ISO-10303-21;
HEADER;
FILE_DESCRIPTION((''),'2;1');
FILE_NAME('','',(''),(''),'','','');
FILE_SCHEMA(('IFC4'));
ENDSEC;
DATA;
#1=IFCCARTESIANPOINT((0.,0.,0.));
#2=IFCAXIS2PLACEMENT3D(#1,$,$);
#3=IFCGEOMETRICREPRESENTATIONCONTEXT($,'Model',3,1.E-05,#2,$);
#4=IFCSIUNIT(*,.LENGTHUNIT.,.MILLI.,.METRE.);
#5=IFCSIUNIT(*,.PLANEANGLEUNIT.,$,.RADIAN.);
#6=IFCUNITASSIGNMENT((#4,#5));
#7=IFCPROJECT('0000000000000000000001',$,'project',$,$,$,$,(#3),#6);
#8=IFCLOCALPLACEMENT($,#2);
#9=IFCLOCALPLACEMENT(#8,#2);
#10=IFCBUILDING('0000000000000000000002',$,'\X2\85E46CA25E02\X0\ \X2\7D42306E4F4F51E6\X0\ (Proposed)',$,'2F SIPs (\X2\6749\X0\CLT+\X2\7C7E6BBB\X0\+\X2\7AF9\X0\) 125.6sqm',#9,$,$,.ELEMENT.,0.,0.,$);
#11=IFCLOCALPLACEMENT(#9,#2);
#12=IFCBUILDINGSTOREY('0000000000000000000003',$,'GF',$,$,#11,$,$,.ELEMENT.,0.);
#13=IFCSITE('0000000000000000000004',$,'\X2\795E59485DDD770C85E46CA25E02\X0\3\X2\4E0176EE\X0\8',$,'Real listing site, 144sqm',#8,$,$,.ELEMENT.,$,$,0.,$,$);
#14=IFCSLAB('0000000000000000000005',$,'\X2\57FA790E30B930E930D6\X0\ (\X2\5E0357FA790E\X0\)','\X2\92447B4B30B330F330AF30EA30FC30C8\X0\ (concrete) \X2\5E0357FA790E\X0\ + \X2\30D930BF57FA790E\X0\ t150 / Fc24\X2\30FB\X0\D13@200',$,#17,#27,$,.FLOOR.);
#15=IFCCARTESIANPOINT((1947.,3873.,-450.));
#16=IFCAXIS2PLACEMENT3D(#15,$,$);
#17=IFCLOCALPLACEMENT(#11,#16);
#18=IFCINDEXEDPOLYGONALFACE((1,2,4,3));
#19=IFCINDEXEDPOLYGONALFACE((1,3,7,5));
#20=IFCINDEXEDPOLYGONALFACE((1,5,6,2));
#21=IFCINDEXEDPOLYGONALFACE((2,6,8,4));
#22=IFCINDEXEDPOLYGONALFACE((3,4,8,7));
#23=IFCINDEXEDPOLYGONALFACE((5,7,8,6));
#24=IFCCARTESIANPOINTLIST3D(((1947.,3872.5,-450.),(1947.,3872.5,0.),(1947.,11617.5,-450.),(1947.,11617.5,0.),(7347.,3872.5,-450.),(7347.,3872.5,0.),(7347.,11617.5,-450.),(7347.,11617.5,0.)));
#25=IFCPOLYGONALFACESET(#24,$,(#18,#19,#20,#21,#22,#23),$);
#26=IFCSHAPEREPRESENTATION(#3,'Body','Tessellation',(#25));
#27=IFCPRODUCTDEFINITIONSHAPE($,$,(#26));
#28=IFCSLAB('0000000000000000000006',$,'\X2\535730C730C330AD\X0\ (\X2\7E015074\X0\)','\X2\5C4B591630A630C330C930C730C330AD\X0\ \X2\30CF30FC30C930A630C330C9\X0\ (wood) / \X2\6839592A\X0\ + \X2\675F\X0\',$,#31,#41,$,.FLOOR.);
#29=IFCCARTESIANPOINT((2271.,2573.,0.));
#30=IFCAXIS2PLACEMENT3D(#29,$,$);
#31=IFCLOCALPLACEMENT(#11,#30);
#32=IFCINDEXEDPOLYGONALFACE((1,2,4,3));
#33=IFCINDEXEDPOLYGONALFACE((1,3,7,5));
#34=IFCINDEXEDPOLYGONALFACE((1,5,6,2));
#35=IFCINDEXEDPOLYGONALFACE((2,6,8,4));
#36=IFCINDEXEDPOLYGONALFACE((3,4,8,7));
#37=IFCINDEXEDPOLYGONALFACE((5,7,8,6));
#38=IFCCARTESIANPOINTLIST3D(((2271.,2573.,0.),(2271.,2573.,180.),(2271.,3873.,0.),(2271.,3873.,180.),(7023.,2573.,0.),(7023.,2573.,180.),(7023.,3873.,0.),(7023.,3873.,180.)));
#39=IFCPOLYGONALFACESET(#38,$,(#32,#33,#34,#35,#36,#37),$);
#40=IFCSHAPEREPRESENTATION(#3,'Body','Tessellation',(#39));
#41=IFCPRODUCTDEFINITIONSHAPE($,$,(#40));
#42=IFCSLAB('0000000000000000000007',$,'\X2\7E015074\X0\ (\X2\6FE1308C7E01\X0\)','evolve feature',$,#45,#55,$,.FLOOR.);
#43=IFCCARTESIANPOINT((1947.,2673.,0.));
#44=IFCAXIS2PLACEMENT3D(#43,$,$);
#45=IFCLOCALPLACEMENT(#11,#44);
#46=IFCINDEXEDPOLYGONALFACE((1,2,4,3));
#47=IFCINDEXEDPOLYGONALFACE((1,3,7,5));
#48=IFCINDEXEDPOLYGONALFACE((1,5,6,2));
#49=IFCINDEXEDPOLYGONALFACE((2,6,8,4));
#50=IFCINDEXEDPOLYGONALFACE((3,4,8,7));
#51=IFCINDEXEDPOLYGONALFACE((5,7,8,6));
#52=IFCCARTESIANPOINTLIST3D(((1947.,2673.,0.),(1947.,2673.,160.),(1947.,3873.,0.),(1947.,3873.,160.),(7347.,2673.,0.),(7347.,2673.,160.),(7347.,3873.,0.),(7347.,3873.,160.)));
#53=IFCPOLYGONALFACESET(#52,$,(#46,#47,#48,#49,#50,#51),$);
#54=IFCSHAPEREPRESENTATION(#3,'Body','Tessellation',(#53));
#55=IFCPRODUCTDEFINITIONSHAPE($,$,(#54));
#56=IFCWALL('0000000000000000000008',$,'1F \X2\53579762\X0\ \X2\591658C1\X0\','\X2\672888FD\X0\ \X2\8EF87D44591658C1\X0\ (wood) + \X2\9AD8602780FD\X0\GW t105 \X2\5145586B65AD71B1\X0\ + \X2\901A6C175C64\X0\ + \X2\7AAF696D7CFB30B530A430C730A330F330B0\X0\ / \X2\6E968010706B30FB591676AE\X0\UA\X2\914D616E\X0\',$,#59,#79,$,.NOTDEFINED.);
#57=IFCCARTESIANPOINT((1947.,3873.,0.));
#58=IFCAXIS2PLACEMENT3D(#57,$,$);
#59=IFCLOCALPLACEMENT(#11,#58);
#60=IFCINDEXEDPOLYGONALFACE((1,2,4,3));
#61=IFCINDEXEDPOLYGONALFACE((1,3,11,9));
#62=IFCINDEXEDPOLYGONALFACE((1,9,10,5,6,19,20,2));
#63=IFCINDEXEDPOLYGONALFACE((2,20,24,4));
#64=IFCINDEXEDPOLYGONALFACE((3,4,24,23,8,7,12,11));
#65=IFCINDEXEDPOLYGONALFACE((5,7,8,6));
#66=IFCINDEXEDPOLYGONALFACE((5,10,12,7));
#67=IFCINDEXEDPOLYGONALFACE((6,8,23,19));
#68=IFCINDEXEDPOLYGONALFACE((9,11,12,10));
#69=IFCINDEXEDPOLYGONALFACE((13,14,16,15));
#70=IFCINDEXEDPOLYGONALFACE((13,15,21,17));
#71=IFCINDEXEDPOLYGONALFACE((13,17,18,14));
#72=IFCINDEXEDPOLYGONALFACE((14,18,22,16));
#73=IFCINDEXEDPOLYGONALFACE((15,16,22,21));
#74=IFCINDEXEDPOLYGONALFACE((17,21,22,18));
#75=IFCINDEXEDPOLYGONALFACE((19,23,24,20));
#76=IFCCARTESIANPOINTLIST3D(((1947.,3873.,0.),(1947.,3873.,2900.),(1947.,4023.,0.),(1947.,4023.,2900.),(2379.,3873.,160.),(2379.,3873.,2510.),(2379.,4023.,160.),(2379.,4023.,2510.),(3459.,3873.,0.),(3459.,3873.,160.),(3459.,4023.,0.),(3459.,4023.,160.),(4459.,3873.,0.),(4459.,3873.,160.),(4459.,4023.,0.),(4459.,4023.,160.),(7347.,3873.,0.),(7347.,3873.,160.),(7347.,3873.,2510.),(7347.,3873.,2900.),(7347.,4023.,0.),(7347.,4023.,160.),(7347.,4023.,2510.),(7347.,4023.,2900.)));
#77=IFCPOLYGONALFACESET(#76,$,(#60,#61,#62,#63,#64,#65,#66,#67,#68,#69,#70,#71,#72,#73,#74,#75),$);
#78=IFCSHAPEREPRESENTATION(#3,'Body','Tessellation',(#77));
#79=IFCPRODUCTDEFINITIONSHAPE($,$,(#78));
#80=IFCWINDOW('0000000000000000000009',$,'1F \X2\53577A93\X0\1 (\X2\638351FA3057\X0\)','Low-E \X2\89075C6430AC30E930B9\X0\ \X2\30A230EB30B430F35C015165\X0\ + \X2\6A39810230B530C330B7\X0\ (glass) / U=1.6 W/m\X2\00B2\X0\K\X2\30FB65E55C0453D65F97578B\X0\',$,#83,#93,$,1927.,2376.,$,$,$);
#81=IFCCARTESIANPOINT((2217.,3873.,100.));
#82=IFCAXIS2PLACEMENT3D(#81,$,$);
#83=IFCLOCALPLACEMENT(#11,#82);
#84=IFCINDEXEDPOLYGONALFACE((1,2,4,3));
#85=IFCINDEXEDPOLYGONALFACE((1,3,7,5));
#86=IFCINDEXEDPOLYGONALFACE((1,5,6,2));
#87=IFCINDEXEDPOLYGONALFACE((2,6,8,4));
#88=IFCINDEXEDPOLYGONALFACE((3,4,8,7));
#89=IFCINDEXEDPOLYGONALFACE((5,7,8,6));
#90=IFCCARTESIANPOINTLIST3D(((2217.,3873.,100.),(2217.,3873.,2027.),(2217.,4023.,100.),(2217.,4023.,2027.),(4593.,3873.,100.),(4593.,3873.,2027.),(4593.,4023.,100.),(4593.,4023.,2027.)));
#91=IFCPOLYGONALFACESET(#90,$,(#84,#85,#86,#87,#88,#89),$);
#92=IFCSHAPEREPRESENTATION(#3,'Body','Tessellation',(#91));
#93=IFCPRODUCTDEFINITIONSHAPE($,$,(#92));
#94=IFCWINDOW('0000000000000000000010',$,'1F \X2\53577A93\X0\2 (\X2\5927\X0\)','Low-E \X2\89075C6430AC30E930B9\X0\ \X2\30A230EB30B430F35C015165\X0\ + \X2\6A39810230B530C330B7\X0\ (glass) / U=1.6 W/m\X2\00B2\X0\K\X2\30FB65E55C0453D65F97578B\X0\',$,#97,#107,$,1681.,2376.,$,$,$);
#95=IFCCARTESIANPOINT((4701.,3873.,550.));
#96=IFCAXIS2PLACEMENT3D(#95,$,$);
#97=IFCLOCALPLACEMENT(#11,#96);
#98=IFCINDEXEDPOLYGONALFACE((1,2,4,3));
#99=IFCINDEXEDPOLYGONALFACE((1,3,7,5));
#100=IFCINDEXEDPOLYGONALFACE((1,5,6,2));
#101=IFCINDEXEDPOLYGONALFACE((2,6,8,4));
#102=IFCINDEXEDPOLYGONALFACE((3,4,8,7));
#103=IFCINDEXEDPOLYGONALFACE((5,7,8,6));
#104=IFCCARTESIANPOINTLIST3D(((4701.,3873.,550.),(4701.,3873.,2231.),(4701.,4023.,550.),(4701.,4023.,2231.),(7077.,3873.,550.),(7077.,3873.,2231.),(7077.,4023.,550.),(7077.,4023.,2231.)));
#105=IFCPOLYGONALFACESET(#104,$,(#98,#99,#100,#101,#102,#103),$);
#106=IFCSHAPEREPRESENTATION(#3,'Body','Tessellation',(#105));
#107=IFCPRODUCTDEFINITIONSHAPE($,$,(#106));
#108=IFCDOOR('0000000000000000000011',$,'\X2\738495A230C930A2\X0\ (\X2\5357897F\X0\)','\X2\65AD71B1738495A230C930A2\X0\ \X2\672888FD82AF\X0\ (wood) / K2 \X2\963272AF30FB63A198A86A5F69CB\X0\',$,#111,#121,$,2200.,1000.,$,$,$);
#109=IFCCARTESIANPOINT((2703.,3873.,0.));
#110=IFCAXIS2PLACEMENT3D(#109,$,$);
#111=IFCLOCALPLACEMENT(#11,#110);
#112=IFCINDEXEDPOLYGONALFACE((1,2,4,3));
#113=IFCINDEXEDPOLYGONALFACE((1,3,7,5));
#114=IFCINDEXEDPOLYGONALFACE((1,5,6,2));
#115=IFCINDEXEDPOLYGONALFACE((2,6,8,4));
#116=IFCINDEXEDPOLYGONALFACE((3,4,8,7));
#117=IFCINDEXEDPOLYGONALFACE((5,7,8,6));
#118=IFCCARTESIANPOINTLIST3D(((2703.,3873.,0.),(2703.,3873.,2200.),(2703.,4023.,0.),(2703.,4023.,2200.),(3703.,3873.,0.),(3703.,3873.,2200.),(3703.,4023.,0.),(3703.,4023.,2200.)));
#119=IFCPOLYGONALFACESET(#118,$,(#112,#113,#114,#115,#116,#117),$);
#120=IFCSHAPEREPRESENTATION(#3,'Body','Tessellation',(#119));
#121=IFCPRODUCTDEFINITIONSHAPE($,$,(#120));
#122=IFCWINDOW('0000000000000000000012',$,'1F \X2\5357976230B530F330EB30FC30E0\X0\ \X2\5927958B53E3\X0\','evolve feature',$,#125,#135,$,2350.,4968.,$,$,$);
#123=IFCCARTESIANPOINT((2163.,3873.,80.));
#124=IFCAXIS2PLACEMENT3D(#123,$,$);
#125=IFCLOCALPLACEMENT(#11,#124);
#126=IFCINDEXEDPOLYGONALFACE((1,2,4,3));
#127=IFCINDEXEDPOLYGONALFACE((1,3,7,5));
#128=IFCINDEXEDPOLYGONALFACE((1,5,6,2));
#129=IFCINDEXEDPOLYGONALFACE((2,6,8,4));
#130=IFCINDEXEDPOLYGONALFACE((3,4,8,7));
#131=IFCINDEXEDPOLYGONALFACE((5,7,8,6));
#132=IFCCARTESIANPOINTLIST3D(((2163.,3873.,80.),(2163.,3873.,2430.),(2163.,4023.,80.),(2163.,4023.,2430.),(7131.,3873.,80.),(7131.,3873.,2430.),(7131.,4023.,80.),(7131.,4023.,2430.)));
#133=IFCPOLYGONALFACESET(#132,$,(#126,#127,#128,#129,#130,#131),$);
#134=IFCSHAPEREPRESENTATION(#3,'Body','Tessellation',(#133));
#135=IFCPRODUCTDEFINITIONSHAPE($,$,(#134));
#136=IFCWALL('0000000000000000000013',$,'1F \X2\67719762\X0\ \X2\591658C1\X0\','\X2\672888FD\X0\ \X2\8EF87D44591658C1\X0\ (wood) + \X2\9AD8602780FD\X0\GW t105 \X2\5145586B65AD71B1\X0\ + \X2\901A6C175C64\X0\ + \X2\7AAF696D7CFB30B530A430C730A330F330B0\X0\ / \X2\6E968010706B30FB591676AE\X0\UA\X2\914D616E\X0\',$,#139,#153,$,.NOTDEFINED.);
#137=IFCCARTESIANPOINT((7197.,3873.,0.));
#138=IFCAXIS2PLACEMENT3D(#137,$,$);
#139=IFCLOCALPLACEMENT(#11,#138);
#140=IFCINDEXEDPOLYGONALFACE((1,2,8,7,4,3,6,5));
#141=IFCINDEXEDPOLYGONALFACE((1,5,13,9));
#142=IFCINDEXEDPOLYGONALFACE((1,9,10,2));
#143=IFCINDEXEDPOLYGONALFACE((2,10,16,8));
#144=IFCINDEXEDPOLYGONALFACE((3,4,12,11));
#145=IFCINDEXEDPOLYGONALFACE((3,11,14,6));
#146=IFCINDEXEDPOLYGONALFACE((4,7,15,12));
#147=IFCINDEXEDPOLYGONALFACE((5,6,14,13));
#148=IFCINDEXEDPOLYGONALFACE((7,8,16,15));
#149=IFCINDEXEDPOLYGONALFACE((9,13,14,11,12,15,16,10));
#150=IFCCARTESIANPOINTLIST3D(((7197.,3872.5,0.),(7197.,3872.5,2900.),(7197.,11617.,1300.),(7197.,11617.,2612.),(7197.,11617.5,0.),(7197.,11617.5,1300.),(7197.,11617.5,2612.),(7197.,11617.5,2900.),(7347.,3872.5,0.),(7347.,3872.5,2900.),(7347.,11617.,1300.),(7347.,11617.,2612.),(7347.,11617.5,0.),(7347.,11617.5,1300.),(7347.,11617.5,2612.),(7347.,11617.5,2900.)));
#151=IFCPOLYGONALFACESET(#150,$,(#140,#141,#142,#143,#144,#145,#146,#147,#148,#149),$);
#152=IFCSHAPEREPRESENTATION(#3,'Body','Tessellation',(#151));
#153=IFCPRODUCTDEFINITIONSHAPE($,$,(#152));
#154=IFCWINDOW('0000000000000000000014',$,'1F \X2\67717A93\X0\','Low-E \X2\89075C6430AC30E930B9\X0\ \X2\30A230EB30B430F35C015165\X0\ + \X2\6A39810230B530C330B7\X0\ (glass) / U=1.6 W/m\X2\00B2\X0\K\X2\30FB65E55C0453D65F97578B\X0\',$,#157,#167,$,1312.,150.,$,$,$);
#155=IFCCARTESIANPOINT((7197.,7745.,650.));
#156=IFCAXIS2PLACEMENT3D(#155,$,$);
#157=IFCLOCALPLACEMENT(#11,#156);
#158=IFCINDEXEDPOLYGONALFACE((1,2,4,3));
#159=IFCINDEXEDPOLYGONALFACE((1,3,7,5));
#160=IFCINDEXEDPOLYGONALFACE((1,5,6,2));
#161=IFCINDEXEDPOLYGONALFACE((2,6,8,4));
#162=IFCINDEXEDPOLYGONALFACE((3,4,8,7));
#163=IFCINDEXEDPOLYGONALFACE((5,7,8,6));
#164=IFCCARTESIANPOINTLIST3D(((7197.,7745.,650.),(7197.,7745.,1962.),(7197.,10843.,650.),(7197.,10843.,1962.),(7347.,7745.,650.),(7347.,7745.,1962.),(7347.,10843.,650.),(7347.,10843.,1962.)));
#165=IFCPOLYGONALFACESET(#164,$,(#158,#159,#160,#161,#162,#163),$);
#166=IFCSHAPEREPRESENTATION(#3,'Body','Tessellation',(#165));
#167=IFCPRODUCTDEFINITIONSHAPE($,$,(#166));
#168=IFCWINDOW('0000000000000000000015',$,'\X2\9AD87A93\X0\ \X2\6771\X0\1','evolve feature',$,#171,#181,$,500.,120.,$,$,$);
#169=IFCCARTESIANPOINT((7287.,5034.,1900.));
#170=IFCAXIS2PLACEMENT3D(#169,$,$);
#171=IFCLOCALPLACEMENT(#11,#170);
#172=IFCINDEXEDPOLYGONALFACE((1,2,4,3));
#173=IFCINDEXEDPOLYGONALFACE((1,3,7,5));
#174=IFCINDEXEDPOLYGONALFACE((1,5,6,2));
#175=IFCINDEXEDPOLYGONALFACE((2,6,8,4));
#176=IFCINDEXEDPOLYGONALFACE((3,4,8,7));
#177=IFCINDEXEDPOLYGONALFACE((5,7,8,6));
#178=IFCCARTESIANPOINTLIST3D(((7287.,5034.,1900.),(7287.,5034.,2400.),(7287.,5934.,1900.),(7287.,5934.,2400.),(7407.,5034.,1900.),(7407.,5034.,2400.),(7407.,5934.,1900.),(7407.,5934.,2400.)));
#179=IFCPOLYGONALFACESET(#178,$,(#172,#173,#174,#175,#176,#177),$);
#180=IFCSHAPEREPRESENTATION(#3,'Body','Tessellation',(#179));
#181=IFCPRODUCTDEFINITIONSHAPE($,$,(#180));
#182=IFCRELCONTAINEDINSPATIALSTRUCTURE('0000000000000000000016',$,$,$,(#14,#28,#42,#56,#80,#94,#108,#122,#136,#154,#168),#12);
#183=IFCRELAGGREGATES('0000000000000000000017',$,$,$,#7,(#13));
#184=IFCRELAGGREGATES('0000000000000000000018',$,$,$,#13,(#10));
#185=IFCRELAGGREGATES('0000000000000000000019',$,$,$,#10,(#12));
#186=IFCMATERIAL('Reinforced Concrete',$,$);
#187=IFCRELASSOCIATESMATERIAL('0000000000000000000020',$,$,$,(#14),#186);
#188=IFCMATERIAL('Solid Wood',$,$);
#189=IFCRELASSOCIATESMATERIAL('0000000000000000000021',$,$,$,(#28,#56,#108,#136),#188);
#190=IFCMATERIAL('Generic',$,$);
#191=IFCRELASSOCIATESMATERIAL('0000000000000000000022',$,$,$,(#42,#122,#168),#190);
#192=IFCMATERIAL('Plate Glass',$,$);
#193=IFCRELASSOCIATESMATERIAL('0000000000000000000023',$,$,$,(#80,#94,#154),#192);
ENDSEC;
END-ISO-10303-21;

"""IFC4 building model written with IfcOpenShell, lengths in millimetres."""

from ifc_helpers import new_model, si_unit, frame, frame_2d, origin, place, context, project, spatial, rectangle, extrude, material, element, fill, save


model = new_model("IFC4")

# Units and contexts
model_context = context("Model", 3, precision=1e-05, world=origin())
ifc_project = project(units=[si_unit("LENGTHUNIT", "METRE", prefix="MILLI"), si_unit("PLANEANGLEUNIT", "RADIAN")], contexts=[model_context])

# Site, building, storey
site_placement = place(None, origin())
site = spatial("IfcSite", under=ifc_project, at=site_placement, Name="神奈川県藤沢市3丁目8", ObjectType="Real listing site, 144sqm", CompositionType="ELEMENT", RefElevation=0.0)
building_placement = place(site_placement, origin())
building = spatial("IfcBuilding", under=site, at=building_placement, Name="藤沢市 終の住処 (Proposed)", ObjectType="2F SIPs (杉CLT+籾殻+竹) 125.6sqm", CompositionType="ELEMENT", ElevationOfRefHeight=0.0, ElevationOfTerrain=0.0)
storey_placement = place(building_placement, origin())
storey = spatial("IfcBuildingStorey", under=building, at=storey_placement, Name="GF", CompositionType="ELEMENT", Elevation=0.0)

# Slabs
ifc_material_1 = material(Name="Reinforced Concrete")
slab_1_placement = place(storey_placement, frame((1947.0, 3873.0, -450.0)))
element("IfcSlab", 1, at=slab_1_placement, inside=storey, material=ifc_material_1, Name="基礎スラブ (布基礎)", Description="鉄筋コンクリート (concrete) 布基礎 + ベタ基礎 t150 / Fc24・D13@200", PredefinedType="FLOOR", context=model_context, shape_type="SweptSolid", body=[
    extrude(rectangle(XDim=5400.0, YDim=7745.0, at=frame_2d((2700.0, 3872.0))), frame((1947.0, 3873.0, -450.0)), (0.0, 0.0, 1.0), 450.0),
])
ifc_material_2 = material(Name="Solid Wood")
slab_2_placement = place(storey_placement, frame((2271.0, 2573.0, 0.0)))
element("IfcSlab", 2, at=slab_2_placement, inside=storey, material=ifc_material_2, Name="南デッキ (縁側)", Description="屋外ウッドデッキ ハードウッド (wood) / 根太 + 束", PredefinedType="FLOOR", context=model_context, shape_type="SweptSolid", body=[
    extrude(rectangle(XDim=4752.0, YDim=1300.0, at=frame_2d((2376.0, 650.0))), frame((2271.0, 2573.0, 0.0)), (0.0, 0.0, 1.0), 180.0),
])
ifc_material_3 = material(Name="Generic")
slab_3_placement = place(storey_placement, frame((1947.0, 2673.0, 0.0)))
element("IfcSlab", 3, at=slab_3_placement, inside=storey, material=ifc_material_3, Name="縁側 (濡れ縁)", Description="evolve feature", PredefinedType="FLOOR", context=model_context, shape_type="SweptSolid", body=[
    extrude(rectangle(XDim=5400.0, YDim=1200.0, at=frame_2d((2700.0, 600.0))), frame((1947.0, 2673.0, 0.0)), (0.0, 0.0, 1.0), 160.0),
])

# Wall, openings, windows, door
wall_1_placement = place(storey_placement, frame((1947.0, 3873.0, 0.0)))
wall_1 = element("IfcWall", 4, at=wall_1_placement, inside=storey, material=ifc_material_2, Name="1F 南面 外壁", Description="木製 軸組外壁 (wood) + 高性能GW t105 充填断熱 + 通気層 + 窯業系サイディング / 準耐火・外皮UA配慮", PredefinedType="NOTDEFINED", context=model_context, shape_type="SweptSolid", body=[
    extrude(rectangle(XDim=5400.0, YDim=150.0, at=frame_2d((2700.0, 75.0))), frame((1947.0, 3873.0, 0.0)), (0.0, 0.0, 1.0), 2900.0),
])
opening_1_placement = place(storey_placement, frame((2217.0, 3873.0, 100.0)))
opening_1 = element("IfcOpeningElement", 5, at=opening_1_placement, cuts=wall_1, PredefinedType="NOTDEFINED", context=model_context, shape_type="SweptSolid", body=[
    extrude(rectangle(XDim=2376.0, YDim=150.0, at=frame_2d((1188.0, 75.0))), frame((2217.0, 3873.0, 100.0)), (0.0, 0.0, 1.0), 1927.0),
])
opening_2_placement = place(storey_placement, frame((4701.0, 3873.0, 550.0)))
opening_2 = element("IfcOpeningElement", 6, at=opening_2_placement, cuts=wall_1, PredefinedType="NOTDEFINED", context=model_context, shape_type="SweptSolid", body=[
    extrude(rectangle(XDim=2376.0, YDim=150.0, at=frame_2d((1188.0, 75.0))), frame((4701.0, 3873.0, 550.0)), (0.0, 0.0, 1.0), 1681.0),
])
opening_3_placement = place(storey_placement, frame((2703.0, 3873.0, 0.0)))
opening_3 = element("IfcOpeningElement", 7, at=opening_3_placement, cuts=wall_1, PredefinedType="NOTDEFINED", context=model_context, shape_type="SweptSolid", body=[
    extrude(rectangle(XDim=1000.0, YDim=150.0, at=frame_2d((500.0, 75.0))), frame((2703.0, 3873.0, 0.0)), (0.0, 0.0, 1.0), 2200.0),
])
opening_4_placement = place(storey_placement, frame((2163.0, 3873.0, 80.0)))
opening_4 = element("IfcOpeningElement", 8, at=opening_4_placement, cuts=wall_1, PredefinedType="NOTDEFINED", context=model_context, shape_type="SweptSolid", body=[
    extrude(rectangle(XDim=4968.0, YDim=150.0, at=frame_2d((2484.0, 75.0))), frame((2163.0, 3873.0, 80.0)), (0.0, 0.0, 1.0), 2350.0),
])
ifc_material_4 = material(Name="Plate Glass")
window_1_placement = place(storey_placement, frame((2217.0, 3873.0, 100.0)))
window_1 = element("IfcWindow", 9, at=window_1_placement, inside=storey, material=ifc_material_4, Name="1F 南窓1 (掃出し)", Description="Low-E 複層ガラス アルゴン封入 + 樹脂サッシ (glass) / U=1.6 W/m²K・日射取得型", OverallHeight=1927.0, OverallWidth=2376.0, context=model_context, shape_type="SweptSolid", body=[
    extrude(rectangle(XDim=2376.0, YDim=150.0, at=frame_2d((1188.0, 75.0))), frame((2217.0, 3873.0, 100.0)), (0.0, 0.0, 1.0), 1927.0),
])
fill(opening_1, window_1)
window_2_placement = place(storey_placement, frame((4701.0, 3873.0, 550.0)))
window_2 = element("IfcWindow", 10, at=window_2_placement, inside=storey, material=ifc_material_4, Name="1F 南窓2 (大)", Description="Low-E 複層ガラス アルゴン封入 + 樹脂サッシ (glass) / U=1.6 W/m²K・日射取得型", OverallHeight=1681.0, OverallWidth=2376.0, context=model_context, shape_type="SweptSolid", body=[
    extrude(rectangle(XDim=2376.0, YDim=150.0, at=frame_2d((1188.0, 75.0))), frame((4701.0, 3873.0, 550.0)), (0.0, 0.0, 1.0), 1681.0),
])
fill(opening_2, window_2)
door_placement = place(storey_placement, frame((2703.0, 3873.0, 0.0)))
door = element("IfcDoor", 11, at=door_placement, inside=storey, material=ifc_material_2, Name="玄関ドア (南西)", Description="断熱玄関ドア 木製芯 (wood) / K2 防犯・採風機構", OverallHeight=2200.0, OverallWidth=1000.0, context=model_context, shape_type="SweptSolid", body=[
    extrude(rectangle(XDim=1000.0, YDim=150.0, at=frame_2d((500.0, 75.0))), frame((2703.0, 3873.0, 0.0)), (0.0, 0.0, 1.0), 2200.0),
])
fill(opening_3, door)
window_3_placement = place(storey_placement, frame((2163.0, 3873.0, 80.0)))
window_3 = element("IfcWindow", 12, at=window_3_placement, inside=storey, material=ifc_material_3, Name="1F 南面サンルーム 大開口", Description="evolve feature", OverallHeight=2350.0, OverallWidth=4968.0, context=model_context, shape_type="SweptSolid", body=[
    extrude(rectangle(XDim=4968.0, YDim=150.0, at=frame_2d((2484.0, 75.0))), frame((2163.0, 3873.0, 80.0)), (0.0, 0.0, 1.0), 2350.0),
])
fill(opening_4, window_3)

# Wall, openings, windows
wall_2_placement = place(storey_placement, frame((7197.0, 3873.0, 0.0)))
wall_2 = element("IfcWall", 13, at=wall_2_placement, inside=storey, material=ifc_material_2, Name="1F 東面 外壁", Description="木製 軸組外壁 (wood) + 高性能GW t105 充填断熱 + 通気層 + 窯業系サイディング / 準耐火・外皮UA配慮", PredefinedType="NOTDEFINED", context=model_context, shape_type="SweptSolid", body=[
    extrude(rectangle(XDim=150.0, YDim=7745.0, at=frame_2d((75.0, 3872.0))), frame((7197.0, 3873.0, 0.0)), (0.0, 0.0, 1.0), 2900.0),
])
opening_5_placement = place(storey_placement, frame((7197.0, 7745.0, 650.0)))
opening_5 = element("IfcOpeningElement", 14, at=opening_5_placement, cuts=wall_2, PredefinedType="NOTDEFINED", context=model_context, shape_type="SweptSolid", body=[
    extrude(rectangle(XDim=150.0, YDim=3098.0, at=frame_2d((75.0, 1549.0))), frame((7197.0, 7745.0, 650.0)), (0.0, 0.0, 1.0), 1312.0),
])
opening_6_placement = place(storey_placement, frame((7287.0, 5034.0, 1900.0)))
opening_6 = element("IfcOpeningElement", 15, at=opening_6_placement, cuts=wall_2, PredefinedType="NOTDEFINED", context=model_context, shape_type="SweptSolid", body=[
    extrude(rectangle(XDim=120.0, YDim=900.0, at=frame_2d((60.0, 450.0))), frame((7287.0, 5034.0, 1900.0)), (0.0, 0.0, 1.0), 500.0),
])
window_4_placement = place(storey_placement, frame((7197.0, 7745.0, 650.0)))
window_4 = element("IfcWindow", 16, at=window_4_placement, inside=storey, material=ifc_material_4, Name="1F 東窓", Description="Low-E 複層ガラス アルゴン封入 + 樹脂サッシ (glass) / U=1.6 W/m²K・日射取得型", OverallHeight=1312.0, OverallWidth=150.0, context=model_context, shape_type="SweptSolid", body=[
    extrude(rectangle(XDim=150.0, YDim=3098.0, at=frame_2d((75.0, 1549.0))), frame((7197.0, 7745.0, 650.0)), (0.0, 0.0, 1.0), 1312.0),
])
fill(opening_5, window_4)
window_5_placement = place(storey_placement, frame((7287.0, 5034.0, 1900.0)))
window_5 = element("IfcWindow", 17, at=window_5_placement, inside=storey, material=ifc_material_3, Name="高窓 東1", Description="evolve feature", OverallHeight=500.0, OverallWidth=120.0, context=model_context, shape_type="SweptSolid", body=[
    extrude(rectangle(XDim=120.0, YDim=900.0, at=frame_2d((60.0, 450.0))), frame((7287.0, 5034.0, 1900.0)), (0.0, 0.0, 1.0), 500.0),
])
fill(opening_6, window_5)

save(model, "model.ifc")
